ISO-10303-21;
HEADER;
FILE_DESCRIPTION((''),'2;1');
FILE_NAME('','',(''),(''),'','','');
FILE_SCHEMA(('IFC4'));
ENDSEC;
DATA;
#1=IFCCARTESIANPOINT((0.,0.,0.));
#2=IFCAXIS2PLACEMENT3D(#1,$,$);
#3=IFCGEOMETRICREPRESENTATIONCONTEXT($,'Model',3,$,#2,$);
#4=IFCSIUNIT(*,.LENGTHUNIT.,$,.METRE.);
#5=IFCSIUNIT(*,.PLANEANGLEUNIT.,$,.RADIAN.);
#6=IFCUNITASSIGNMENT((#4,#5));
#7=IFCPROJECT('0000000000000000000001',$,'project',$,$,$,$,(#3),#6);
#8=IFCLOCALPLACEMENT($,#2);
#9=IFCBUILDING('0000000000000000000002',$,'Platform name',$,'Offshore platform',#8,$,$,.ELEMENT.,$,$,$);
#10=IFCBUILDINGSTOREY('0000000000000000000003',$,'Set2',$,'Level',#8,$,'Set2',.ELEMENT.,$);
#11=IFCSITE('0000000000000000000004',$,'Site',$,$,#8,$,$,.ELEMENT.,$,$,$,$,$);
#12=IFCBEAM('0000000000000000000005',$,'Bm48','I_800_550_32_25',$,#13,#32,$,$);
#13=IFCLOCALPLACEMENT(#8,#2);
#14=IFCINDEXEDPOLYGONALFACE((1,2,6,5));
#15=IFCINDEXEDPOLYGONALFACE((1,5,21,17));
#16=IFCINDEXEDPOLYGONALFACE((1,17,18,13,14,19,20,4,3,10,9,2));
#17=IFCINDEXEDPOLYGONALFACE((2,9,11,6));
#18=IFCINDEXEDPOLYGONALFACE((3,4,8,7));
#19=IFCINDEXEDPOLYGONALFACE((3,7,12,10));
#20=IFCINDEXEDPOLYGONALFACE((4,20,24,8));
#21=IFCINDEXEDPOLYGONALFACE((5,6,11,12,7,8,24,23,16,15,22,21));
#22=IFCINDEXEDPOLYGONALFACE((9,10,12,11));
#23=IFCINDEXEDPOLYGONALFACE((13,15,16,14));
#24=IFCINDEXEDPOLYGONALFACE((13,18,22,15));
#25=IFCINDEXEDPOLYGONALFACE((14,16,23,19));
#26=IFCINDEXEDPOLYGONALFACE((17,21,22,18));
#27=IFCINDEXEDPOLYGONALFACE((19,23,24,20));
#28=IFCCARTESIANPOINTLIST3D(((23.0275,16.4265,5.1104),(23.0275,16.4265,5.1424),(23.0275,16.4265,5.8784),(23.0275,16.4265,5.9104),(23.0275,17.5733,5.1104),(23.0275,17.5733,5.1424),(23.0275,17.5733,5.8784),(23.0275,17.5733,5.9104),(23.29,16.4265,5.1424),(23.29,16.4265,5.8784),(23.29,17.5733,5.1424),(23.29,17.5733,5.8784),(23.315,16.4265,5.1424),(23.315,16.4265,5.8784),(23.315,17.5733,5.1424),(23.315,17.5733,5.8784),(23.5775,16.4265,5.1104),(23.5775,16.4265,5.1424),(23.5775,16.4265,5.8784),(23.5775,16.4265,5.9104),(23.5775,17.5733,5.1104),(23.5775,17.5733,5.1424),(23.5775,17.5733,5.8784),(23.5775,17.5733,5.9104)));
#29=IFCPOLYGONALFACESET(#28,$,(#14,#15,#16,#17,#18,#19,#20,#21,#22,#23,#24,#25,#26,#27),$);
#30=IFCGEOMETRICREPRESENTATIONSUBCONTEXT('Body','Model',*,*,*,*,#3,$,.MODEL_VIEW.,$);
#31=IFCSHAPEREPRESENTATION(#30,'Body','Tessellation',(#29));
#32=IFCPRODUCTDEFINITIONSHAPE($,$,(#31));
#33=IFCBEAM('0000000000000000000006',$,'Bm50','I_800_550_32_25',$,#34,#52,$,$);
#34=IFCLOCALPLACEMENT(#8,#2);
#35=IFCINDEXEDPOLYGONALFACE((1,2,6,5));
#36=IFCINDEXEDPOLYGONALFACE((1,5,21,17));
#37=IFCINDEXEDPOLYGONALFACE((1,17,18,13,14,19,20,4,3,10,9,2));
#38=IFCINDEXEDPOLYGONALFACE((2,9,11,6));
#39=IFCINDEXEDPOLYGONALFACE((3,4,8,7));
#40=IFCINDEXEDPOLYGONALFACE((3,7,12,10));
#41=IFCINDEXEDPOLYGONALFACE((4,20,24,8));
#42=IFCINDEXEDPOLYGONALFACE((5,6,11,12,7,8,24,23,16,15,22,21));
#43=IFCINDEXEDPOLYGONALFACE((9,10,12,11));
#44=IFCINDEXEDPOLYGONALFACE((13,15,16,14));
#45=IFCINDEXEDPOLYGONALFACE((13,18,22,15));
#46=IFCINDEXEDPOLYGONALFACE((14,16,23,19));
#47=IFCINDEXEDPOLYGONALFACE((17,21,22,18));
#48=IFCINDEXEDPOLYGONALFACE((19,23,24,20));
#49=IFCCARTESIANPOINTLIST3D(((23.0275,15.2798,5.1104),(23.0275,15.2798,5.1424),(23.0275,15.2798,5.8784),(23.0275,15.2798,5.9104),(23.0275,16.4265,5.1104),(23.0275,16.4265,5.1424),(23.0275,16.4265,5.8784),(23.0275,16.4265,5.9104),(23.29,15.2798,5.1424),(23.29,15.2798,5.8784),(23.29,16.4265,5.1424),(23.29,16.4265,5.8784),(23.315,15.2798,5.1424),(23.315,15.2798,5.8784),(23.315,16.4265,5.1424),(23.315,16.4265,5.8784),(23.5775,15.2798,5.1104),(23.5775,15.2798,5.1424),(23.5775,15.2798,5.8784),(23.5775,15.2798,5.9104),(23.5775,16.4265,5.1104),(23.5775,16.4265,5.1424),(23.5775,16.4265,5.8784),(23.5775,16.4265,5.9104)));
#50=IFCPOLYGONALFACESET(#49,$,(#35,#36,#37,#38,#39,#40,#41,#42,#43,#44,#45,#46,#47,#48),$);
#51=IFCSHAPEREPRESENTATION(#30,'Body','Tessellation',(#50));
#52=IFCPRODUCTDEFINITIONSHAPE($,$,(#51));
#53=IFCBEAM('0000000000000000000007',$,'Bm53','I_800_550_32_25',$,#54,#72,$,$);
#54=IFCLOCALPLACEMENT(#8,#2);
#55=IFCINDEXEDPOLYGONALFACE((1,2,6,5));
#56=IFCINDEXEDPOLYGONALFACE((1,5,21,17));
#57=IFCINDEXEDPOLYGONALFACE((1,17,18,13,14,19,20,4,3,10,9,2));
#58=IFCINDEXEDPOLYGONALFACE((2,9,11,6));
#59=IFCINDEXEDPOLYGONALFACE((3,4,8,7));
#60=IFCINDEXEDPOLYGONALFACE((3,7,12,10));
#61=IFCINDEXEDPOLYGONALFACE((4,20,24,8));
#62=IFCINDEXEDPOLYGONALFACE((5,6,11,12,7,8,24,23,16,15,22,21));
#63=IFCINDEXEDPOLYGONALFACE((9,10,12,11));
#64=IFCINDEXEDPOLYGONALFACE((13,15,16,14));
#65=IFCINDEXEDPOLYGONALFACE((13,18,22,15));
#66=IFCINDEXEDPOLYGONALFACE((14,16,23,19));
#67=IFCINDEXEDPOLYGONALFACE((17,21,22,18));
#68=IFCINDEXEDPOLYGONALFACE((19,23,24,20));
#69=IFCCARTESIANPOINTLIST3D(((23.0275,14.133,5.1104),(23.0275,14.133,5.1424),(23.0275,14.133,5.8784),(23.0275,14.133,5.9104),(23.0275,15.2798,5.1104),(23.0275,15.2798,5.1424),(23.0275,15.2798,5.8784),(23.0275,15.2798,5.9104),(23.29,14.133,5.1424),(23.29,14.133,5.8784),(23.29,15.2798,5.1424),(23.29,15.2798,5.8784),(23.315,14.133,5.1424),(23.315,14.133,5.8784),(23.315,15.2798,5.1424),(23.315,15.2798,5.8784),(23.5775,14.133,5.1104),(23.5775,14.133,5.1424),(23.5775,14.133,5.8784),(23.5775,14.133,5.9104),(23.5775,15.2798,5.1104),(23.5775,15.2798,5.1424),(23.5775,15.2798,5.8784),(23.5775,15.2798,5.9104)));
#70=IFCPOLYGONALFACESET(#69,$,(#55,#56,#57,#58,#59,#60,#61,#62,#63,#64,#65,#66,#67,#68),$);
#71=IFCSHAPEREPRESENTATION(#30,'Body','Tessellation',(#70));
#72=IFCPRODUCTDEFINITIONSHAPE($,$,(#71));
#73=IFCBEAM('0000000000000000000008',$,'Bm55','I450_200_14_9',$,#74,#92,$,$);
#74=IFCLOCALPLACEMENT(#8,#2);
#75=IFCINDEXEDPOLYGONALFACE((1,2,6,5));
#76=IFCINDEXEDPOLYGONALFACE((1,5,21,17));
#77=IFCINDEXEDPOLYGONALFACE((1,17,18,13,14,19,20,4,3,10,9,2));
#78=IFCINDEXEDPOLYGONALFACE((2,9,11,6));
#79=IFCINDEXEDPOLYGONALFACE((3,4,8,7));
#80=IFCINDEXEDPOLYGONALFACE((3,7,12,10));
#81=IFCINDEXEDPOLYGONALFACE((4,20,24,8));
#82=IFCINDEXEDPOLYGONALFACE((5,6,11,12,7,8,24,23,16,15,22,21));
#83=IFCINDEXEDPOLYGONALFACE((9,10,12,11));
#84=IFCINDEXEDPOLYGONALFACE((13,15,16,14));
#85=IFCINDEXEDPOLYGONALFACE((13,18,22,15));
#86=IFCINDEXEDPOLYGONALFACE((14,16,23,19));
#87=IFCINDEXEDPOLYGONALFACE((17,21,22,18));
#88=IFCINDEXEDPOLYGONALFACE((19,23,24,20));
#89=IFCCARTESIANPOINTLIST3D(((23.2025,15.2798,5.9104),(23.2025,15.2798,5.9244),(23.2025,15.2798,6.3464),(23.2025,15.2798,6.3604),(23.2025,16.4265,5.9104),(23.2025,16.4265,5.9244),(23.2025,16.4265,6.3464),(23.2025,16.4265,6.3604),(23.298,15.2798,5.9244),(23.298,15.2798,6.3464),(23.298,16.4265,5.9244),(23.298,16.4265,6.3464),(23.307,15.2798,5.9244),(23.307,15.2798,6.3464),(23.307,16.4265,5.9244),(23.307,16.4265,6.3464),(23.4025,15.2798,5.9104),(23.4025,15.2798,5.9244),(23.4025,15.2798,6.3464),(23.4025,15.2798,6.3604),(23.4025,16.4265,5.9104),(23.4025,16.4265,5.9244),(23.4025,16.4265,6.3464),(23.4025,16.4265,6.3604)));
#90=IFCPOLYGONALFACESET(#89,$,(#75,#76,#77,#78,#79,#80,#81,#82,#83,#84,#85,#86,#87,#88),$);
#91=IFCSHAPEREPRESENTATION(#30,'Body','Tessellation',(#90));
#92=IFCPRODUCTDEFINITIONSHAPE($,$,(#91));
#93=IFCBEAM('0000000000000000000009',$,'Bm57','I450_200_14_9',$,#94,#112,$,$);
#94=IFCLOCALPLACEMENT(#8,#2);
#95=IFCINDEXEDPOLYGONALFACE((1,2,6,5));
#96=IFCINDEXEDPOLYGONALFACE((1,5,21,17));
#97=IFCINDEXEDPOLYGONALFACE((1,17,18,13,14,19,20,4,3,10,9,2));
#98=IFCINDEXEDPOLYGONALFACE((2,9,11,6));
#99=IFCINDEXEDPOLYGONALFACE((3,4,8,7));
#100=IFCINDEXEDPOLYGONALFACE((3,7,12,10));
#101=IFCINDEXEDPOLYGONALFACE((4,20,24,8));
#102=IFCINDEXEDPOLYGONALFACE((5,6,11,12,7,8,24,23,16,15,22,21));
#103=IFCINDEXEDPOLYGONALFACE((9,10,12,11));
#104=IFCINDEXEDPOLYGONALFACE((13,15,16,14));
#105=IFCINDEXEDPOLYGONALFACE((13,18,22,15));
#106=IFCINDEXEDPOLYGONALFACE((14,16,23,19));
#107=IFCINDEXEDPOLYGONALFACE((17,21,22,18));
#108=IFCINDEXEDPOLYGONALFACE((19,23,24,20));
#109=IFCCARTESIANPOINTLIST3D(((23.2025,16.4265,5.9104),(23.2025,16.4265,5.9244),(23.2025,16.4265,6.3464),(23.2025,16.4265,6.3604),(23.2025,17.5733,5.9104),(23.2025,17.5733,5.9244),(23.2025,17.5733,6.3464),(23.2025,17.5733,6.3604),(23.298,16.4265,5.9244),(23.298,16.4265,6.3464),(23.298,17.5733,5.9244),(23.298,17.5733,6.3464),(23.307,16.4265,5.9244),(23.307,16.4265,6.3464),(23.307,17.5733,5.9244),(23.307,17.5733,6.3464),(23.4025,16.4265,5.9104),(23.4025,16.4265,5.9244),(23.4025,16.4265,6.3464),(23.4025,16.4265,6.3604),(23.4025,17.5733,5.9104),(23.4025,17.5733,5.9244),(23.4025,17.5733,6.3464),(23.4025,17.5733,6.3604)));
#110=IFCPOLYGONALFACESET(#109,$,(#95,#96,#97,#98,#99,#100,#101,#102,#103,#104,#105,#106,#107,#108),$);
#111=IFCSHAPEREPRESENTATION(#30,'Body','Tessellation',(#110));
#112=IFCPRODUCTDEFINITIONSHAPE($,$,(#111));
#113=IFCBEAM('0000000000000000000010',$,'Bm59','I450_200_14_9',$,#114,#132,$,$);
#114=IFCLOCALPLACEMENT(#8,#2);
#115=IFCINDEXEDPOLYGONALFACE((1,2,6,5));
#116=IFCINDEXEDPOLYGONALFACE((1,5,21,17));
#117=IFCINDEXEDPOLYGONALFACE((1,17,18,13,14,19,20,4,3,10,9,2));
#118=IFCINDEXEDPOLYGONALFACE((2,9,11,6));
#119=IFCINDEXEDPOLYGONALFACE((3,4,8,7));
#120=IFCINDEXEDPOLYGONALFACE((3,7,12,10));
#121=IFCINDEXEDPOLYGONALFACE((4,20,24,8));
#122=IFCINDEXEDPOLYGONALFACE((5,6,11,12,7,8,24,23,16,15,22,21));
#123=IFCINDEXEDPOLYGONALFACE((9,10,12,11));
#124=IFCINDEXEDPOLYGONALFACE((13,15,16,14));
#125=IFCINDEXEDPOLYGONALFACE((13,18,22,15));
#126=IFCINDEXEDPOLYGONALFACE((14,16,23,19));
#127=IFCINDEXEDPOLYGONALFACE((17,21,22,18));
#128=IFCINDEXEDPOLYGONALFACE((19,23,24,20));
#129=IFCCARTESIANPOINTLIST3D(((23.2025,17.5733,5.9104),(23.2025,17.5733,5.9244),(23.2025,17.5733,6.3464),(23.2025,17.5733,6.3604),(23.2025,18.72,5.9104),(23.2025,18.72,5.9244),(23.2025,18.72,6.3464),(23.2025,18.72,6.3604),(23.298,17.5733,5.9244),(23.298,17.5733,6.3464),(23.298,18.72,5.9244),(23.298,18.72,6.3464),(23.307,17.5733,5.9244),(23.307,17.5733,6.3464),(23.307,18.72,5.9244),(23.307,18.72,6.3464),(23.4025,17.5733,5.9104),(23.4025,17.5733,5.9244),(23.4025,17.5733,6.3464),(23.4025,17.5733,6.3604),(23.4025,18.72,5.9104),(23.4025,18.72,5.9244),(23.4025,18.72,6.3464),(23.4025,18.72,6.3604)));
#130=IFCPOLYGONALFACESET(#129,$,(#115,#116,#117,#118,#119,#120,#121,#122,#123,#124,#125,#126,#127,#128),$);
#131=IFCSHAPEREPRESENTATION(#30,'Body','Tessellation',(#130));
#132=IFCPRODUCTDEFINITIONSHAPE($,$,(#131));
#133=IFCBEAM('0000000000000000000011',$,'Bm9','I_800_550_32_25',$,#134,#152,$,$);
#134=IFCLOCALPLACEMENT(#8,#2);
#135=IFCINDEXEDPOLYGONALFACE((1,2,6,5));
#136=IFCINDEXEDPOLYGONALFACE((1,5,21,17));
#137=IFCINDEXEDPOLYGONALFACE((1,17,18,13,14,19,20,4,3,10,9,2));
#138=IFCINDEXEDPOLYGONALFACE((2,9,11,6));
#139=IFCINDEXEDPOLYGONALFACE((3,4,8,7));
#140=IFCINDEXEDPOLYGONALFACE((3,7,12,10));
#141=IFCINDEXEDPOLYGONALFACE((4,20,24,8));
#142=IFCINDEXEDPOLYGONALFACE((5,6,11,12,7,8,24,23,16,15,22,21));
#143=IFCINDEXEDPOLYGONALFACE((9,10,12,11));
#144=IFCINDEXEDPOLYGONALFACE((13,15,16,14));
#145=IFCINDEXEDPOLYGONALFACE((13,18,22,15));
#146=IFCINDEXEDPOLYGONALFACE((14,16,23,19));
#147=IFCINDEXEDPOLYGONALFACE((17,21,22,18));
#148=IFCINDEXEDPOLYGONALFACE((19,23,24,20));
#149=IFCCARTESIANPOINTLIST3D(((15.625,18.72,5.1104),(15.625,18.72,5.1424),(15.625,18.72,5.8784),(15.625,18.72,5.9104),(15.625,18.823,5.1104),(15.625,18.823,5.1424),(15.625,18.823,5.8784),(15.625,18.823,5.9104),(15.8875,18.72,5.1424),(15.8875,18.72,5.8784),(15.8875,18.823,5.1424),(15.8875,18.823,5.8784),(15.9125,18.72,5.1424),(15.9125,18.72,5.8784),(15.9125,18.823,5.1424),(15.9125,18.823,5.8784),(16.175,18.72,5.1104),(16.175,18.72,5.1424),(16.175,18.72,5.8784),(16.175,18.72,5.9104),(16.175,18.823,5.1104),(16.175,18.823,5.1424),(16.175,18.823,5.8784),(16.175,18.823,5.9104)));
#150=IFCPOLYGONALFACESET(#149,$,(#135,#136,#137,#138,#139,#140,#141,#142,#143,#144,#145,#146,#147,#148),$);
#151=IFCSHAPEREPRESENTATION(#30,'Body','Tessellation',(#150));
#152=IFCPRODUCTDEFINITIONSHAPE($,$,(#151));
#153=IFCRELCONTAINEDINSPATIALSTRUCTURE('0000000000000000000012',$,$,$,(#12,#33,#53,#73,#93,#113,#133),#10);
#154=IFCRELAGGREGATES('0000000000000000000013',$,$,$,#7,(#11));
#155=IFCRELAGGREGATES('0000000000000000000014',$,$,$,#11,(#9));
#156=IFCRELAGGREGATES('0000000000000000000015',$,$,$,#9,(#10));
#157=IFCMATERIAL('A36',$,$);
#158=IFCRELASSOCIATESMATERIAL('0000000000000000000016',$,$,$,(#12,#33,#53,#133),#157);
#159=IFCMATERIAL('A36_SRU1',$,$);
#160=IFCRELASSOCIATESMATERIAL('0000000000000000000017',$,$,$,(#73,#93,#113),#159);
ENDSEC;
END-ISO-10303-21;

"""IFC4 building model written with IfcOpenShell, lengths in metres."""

from ifc_helpers import new_model, si_unit, frame, origin, origin_2d, place, context, subcontext, project, spatial, i_section, extrude, source, transform, mapped, material, element, save


model = new_model("IFC4")

# Units and contexts
model_context = context("Model", 3, world=origin())
body_context = subcontext(model_context, "Body", "Model", "MODEL_VIEW")
ifc_project = project(units=[si_unit("LENGTHUNIT", "METRE"), si_unit("PLANEANGLEUNIT", "RADIAN")], contexts=[model_context])

# Site, building, storey
placement_1 = place(None, origin())
site = spatial("IfcSite", under=ifc_project, at=placement_1, Name="Site", CompositionType="ELEMENT")
building = spatial("IfcBuilding", under=site, at=placement_1, Name="Platform name", ObjectType="Offshore platform", CompositionType="ELEMENT")
storey = spatial("IfcBuildingStorey", under=building, at=placement_1, Name="Set2", ObjectType="Level", LongName="Set2", CompositionType="ELEMENT")

# Beams
ifc_material_1 = material(Name="A36")
ifc_material_2 = material(Name="A36_SRU1")
shared_shape_1 = source(origin(), body_context, "Body", "SweptSolid", [
    extrude(i_section(OverallWidth=0.55, OverallDepth=0.8, WebThickness=0.025, FlangeThickness=0.032, FilletRadius=0.0, at=origin_2d()), frame((0.0, 0.0, 0.0), z_axis=(0.0, -1.0, 0.0), x_axis=(1.0, 0.0, 0.0)), (0.0, 0.0, 1.0), 1.1467),
])
placement_2 = place(None, origin())
placement_3 = place(placement_2, origin())
placement_4 = place(placement_3, origin())
beam_1_placement = place(placement_4, frame((23.3025, 17.5733, 5.5104)))
element("IfcBeam", 1, at=beam_1_placement, inside=storey, material=ifc_material_1, Name="Bm48", Description="I_800_550_32_25", context=body_context, shape_type="MappedRepresentation", body=[
    mapped(shared_shape_1, transform((0.0, 0.0, 0.0), scale=1.0)),
])
shared_shape_2 = source(origin(), body_context, "Body", "SweptSolid", [
    extrude(i_section(OverallWidth=0.55, OverallDepth=0.8, WebThickness=0.025, FlangeThickness=0.032, FilletRadius=0.0, at=origin_2d()), frame((0.0, 0.0, 0.0), z_axis=(0.0, -1.0, 0.0), x_axis=(1.0, 0.0, 0.0)), (0.0, 0.0, 1.0), 1.1467),
])
placement_5 = place(None, origin())
placement_6 = place(placement_5, origin())
placement_7 = place(placement_6, origin())
beam_2_placement = place(placement_7, frame((23.3025, 16.4265, 5.5104)))
element("IfcBeam", 2, at=beam_2_placement, inside=storey, material=ifc_material_1, Name="Bm50", Description="I_800_550_32_25", context=body_context, shape_type="MappedRepresentation", body=[
    mapped(shared_shape_2, transform((0.0, 0.0, 0.0), scale=1.0)),
])
shared_shape_3 = source(origin(), body_context, "Body", "SweptSolid", [
    extrude(i_section(OverallWidth=0.55, OverallDepth=0.8, WebThickness=0.025, FlangeThickness=0.032, FilletRadius=0.0, at=origin_2d()), frame((0.0, 0.0, 0.0), z_axis=(0.0, -1.0, 0.0), x_axis=(1.0, 0.0, 0.0)), (0.0, 0.0, 1.0), 1.1467),
])
placement_8 = place(None, origin())
placement_9 = place(placement_8, origin())
placement_10 = place(placement_9, origin())
beam_3_placement = place(placement_10, frame((23.3025, 15.2797, 5.5104)))
element("IfcBeam", 3, at=beam_3_placement, inside=storey, material=ifc_material_1, Name="Bm53", Description="I_800_550_32_25", context=body_context, shape_type="MappedRepresentation", body=[
    mapped(shared_shape_3, transform((0.0, 0.0, 0.0), scale=1.0)),
])
shared_shape_4 = source(origin(), body_context, "Body", "SweptSolid", [
    extrude(i_section(OverallWidth=0.2, OverallDepth=0.45, WebThickness=0.009, FlangeThickness=0.014, FilletRadius=0.0, at=origin_2d()), frame((0.0, 0.0, 0.0), z_axis=(0.0, 1.0, 0.0), x_axis=(-1.0, 0.0, 0.0)), (0.0, 0.0, 1.0), 1.1467),
])
placement_11 = place(None, origin())
placement_12 = place(placement_11, origin())
placement_13 = place(placement_12, origin())
beam_4_placement = place(placement_13, frame((23.3025, 15.2797, 6.1354)))
element("IfcBeam", 4, at=beam_4_placement, inside=storey, material=ifc_material_2, Name="Bm55", Description="I450_200_14_9", context=body_context, shape_type="MappedRepresentation", body=[
    mapped(shared_shape_4, transform((0.0, 0.0, 0.0), scale=1.0)),
])
shared_shape_5 = source(origin(), body_context, "Body", "SweptSolid", [
    extrude(i_section(OverallWidth=0.2, OverallDepth=0.45, WebThickness=0.009, FlangeThickness=0.014, FilletRadius=0.0, at=origin_2d()), frame((0.0, 0.0, 0.0), z_axis=(0.0, 1.0, 0.0), x_axis=(-1.0, 0.0, 0.0)), (0.0, 0.0, 1.0), 1.1467),
])
placement_14 = place(None, origin())
placement_15 = place(placement_14, origin())
placement_16 = place(placement_15, origin())
beam_5_placement = place(placement_16, frame((23.3025, 16.4265, 6.1354)))
element("IfcBeam", 5, at=beam_5_placement, inside=storey, material=ifc_material_2, Name="Bm57", Description="I450_200_14_9", context=body_context, shape_type="MappedRepresentation", body=[
    mapped(shared_shape_5, transform((0.0, 0.0, 0.0), scale=1.0)),
])
shared_shape_6 = source(origin(), body_context, "Body", "SweptSolid", [
    extrude(i_section(OverallWidth=0.2, OverallDepth=0.45, WebThickness=0.009, FlangeThickness=0.014, FilletRadius=0.0, at=origin_2d()), frame((0.0, 0.0, 0.0), z_axis=(0.0, 1.0, 0.0), x_axis=(-1.0, 0.0, 0.0)), (0.0, 0.0, 1.0), 1.1467),
])
placement_17 = place(None, origin())
placement_18 = place(placement_17, origin())
placement_19 = place(placement_18, origin())
beam_6_placement = place(placement_19, frame((23.3025, 17.5733, 6.1354)))
element("IfcBeam", 6, at=beam_6_placement, inside=storey, material=ifc_material_2, Name="Bm59", Description="I450_200_14_9", context=body_context, shape_type="MappedRepresentation", body=[
    mapped(shared_shape_6, transform((0.0, 0.0, 0.0), scale=1.0)),
])
shared_shape_7 = source(origin(), body_context, "Body", "SweptSolid", [
    extrude(i_section(OverallWidth=0.55, OverallDepth=0.8, WebThickness=0.025, FlangeThickness=0.032, FilletRadius=0.0, at=origin_2d()), frame((0.0, 0.0, 0.0), z_axis=(0.0, -1.0, 0.0), x_axis=(1.0, 0.0, 0.0)), (0.0, 0.0, 1.0), 0.103),
])
placement_20 = place(None, origin())
placement_21 = place(placement_20, origin())
placement_22 = place(placement_21, origin())
beam_7_placement = place(placement_22, frame((15.9, 18.823, 5.5104)))
element("IfcBeam", 7, at=beam_7_placement, inside=storey, material=ifc_material_1, Name="Bm9", Description="I_800_550_32_25", context=body_context, shape_type="MappedRepresentation", body=[
    mapped(shared_shape_7, transform((0.0, 0.0, 0.0), scale=1.0)),
])

save(model, "model.ifc")
